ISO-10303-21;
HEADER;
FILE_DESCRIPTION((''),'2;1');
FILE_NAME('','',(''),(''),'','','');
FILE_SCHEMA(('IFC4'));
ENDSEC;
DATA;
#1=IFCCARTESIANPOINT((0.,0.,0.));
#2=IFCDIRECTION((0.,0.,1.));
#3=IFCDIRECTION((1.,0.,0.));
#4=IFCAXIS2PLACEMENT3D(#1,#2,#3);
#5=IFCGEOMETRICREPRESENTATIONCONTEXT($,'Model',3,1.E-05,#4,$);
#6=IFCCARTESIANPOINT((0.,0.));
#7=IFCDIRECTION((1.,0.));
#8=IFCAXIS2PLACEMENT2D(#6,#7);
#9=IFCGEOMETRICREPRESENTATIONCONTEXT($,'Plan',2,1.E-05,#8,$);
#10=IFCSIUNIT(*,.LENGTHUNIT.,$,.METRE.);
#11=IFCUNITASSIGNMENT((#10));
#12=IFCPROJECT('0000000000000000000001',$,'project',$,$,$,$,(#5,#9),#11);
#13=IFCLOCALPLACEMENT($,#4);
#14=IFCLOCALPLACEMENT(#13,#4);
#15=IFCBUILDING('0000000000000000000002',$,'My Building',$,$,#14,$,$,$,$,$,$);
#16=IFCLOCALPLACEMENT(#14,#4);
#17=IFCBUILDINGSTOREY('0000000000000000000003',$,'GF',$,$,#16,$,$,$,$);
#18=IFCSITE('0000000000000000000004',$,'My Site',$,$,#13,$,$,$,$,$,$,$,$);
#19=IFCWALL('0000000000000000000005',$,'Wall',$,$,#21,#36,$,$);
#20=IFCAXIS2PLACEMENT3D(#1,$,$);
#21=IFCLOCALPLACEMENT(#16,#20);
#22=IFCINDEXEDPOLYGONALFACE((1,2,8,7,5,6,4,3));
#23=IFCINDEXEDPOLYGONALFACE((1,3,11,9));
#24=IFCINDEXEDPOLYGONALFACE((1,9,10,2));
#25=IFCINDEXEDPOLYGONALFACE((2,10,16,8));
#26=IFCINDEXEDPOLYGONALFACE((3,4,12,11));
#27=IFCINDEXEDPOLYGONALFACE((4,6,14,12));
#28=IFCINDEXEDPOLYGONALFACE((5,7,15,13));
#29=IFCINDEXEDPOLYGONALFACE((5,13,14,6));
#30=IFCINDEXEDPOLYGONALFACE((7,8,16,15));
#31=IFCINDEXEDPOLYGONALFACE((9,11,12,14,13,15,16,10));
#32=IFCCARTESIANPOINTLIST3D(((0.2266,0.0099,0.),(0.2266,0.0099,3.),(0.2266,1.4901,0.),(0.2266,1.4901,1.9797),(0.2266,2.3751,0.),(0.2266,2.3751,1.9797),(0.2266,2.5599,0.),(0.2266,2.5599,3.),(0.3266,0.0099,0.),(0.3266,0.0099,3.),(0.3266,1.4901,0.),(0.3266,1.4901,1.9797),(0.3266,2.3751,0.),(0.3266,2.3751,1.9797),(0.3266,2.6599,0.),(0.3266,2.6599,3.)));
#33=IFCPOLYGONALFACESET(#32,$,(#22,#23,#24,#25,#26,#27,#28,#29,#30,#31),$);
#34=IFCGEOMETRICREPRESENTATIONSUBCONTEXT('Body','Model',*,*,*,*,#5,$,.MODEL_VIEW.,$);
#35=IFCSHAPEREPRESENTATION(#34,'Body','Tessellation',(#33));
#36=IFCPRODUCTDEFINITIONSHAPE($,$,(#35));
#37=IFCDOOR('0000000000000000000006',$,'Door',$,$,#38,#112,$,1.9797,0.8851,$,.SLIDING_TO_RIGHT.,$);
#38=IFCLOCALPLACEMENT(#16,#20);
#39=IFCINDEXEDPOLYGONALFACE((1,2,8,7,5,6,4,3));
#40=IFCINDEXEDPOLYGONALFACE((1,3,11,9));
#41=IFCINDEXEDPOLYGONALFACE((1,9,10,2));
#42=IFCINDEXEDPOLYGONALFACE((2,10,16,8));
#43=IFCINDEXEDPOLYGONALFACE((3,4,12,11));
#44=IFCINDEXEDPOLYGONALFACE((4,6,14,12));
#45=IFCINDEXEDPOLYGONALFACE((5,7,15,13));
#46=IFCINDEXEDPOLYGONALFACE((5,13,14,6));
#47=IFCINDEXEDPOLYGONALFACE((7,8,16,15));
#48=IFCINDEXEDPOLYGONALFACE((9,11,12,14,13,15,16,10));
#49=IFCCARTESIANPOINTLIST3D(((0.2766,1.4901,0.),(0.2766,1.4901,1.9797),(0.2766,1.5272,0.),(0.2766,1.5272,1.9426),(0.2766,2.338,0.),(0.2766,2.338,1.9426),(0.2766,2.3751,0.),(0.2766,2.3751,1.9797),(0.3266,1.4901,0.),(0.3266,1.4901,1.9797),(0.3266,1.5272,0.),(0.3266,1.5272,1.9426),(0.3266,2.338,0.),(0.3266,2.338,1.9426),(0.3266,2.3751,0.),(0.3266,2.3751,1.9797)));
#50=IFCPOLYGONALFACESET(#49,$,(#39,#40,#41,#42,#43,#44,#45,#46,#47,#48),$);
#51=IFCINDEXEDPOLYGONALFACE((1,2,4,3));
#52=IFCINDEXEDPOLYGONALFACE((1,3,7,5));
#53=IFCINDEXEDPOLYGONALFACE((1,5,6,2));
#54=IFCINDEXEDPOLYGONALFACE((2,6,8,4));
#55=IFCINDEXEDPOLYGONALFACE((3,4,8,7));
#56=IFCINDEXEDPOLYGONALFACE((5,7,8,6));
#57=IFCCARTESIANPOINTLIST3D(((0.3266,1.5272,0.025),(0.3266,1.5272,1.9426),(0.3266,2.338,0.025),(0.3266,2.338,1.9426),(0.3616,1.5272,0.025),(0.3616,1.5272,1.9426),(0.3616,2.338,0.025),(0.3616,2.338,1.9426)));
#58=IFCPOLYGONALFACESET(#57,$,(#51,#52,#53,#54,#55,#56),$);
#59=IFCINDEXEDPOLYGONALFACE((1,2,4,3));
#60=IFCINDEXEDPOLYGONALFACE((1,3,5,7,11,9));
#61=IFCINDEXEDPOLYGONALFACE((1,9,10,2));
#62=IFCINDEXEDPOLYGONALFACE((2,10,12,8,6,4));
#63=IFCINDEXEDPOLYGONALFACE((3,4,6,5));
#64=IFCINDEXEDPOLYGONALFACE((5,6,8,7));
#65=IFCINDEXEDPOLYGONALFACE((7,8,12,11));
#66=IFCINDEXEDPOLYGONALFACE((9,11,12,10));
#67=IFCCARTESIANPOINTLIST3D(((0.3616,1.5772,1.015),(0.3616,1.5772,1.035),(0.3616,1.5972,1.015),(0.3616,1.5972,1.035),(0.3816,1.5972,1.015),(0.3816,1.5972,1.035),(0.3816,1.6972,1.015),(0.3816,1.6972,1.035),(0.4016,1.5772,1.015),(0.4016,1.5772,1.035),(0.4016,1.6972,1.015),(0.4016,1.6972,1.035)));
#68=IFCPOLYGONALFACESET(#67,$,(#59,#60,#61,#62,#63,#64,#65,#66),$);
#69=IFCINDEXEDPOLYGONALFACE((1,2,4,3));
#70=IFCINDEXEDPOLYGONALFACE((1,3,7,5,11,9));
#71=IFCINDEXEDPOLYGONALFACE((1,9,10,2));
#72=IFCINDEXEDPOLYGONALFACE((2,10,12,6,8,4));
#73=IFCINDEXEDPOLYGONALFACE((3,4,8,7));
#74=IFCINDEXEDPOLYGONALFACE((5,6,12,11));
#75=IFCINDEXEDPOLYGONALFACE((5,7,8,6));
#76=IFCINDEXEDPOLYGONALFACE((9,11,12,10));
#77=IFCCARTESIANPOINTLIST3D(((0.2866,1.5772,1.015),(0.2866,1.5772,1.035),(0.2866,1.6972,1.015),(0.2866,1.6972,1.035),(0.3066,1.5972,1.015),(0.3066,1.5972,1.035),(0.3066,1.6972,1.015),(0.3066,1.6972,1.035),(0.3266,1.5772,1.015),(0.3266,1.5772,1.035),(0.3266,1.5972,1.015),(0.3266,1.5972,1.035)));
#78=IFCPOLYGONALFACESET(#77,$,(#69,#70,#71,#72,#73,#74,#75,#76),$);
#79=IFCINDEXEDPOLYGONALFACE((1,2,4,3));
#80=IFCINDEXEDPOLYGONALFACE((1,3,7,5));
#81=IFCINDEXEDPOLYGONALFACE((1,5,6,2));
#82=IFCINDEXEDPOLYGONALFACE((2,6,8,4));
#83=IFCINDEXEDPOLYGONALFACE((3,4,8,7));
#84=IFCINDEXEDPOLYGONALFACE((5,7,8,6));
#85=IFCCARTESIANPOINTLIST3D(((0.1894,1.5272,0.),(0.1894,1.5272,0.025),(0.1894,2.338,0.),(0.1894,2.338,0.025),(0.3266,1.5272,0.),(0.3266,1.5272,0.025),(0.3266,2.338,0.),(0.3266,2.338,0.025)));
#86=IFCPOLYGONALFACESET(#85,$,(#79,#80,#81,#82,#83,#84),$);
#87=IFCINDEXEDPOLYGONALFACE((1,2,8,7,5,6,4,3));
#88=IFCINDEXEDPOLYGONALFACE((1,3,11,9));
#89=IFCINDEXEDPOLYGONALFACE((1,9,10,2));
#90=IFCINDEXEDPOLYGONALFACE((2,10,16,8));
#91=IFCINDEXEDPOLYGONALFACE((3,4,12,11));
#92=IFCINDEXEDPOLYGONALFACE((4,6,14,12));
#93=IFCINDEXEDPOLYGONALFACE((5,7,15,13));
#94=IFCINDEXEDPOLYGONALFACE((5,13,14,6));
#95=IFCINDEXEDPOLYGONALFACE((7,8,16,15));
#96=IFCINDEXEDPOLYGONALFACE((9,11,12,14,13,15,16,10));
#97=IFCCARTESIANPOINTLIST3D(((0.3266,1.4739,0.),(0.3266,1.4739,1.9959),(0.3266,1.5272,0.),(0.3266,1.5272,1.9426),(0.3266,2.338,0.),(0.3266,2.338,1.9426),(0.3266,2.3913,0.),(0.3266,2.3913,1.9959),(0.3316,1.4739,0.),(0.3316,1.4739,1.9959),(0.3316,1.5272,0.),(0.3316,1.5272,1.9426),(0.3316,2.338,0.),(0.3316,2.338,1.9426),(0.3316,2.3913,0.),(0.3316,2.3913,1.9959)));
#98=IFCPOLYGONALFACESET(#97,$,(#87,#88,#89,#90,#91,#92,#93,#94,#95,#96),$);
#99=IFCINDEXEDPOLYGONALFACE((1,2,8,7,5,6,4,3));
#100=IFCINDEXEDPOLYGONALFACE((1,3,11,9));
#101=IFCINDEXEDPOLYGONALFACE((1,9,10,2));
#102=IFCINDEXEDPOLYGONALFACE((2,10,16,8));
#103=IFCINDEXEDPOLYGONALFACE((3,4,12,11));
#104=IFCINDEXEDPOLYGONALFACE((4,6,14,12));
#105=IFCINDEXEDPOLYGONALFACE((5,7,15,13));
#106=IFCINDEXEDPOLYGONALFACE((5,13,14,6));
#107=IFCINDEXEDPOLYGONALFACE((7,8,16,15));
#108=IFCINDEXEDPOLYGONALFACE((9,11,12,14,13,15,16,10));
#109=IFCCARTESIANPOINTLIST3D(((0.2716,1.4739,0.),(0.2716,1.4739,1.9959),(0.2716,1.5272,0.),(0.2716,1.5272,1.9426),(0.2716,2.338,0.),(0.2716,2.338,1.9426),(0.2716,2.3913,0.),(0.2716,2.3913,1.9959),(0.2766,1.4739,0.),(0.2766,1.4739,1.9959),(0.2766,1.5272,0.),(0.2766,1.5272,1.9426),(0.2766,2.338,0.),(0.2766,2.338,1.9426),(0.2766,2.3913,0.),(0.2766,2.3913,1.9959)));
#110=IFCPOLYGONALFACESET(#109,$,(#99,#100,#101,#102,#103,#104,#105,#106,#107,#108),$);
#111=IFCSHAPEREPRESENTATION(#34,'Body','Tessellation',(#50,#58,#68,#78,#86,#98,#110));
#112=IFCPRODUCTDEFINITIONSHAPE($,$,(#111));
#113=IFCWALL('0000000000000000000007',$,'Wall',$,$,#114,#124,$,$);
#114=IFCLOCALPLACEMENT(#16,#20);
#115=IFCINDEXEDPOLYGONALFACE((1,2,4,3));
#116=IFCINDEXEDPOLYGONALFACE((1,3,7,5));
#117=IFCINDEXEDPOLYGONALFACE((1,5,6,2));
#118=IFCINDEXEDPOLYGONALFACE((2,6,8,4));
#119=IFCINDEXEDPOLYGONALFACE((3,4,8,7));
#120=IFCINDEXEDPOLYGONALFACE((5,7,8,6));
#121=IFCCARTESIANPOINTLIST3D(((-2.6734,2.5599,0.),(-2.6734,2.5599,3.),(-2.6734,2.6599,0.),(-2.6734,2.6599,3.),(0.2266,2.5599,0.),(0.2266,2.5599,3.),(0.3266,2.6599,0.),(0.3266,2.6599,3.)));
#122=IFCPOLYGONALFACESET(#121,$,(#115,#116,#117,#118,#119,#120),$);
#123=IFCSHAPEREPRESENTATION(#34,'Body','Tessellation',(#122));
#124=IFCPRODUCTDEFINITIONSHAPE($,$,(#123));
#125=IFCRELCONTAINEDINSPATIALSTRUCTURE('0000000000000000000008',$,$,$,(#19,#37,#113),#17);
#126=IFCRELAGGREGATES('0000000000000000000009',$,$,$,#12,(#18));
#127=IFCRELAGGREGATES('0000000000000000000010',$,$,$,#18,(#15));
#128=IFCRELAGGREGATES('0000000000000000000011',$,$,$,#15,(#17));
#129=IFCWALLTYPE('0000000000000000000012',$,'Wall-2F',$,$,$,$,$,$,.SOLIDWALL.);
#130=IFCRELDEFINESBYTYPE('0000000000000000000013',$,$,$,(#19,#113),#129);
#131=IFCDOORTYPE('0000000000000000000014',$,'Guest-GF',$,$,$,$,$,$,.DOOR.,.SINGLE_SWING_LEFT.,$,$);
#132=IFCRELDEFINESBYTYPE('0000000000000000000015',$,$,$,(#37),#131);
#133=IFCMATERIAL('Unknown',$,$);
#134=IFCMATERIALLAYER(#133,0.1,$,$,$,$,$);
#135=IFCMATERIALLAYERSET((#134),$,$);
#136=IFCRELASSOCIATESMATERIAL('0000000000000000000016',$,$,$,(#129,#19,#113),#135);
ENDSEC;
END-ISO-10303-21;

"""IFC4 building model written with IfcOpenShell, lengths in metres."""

from ifc_helpers import new_model, entity, si_unit, frame, origin_with_axes, origin_2d_with_axis, place, context, subcontext, project, spatial, line, indexed_curve, outline, extrude, shape, source, transform, mapped, material, layer, layer_set, layer_usage, type_object, type_shapes, element, fill, save


model = new_model("IFC4")

# Units and contexts
model_context = context("Model", 3, precision=1e-05, world=origin_with_axes())
plan_context = context("Plan", 2, precision=1e-05, world=origin_2d_with_axis())
body_context_1 = subcontext(model_context, "Body", "Model", "MODEL_VIEW")
body_context_2 = subcontext(plan_context, "Body", "Plan", "PLAN_VIEW")
ifc_project = project(units=[si_unit("LENGTHUNIT", "METRE")], contexts=[model_context, plan_context])

# Site, building, storey
site_placement = place(None, origin_with_axes())
site = spatial("IfcSite", under=ifc_project, at=site_placement, Name="My Site")
building_placement = place(site_placement, origin_with_axes())
building = spatial("IfcBuilding", under=site, at=building_placement, Name="My Building")
storey_placement = place(building_placement, origin_with_axes())
storey = spatial("IfcBuildingStorey", under=building, at=storey_placement, Name="GF")

# Shared definitions
ifc_material = material(Name="Unknown")

# Shared definitions
ifc_layer_1 = layer(ifc_material, 0.1)
ifc_layer_set_1 = layer_set([ifc_layer_1])
wall_type = type_object("IfcWallType", Name="Wall-2F", PredefinedType="SOLIDWALL", material=ifc_layer_set_1)

# Wall, opening, door
ifc_layer_usage_1 = layer_usage(ifc_layer_set_1, "AXIS2", "POSITIVE", 0.0)
wall_1_placement = place(storey_placement, frame((0.3266, 0.0099, 0.0), z_axis=(0.0, 0.0, 1.0), x_axis=(0.0, 1.0, 0.0)))
wall_1 = element("IfcWall", 1, at=wall_1_placement, inside=storey, type_object=wall_type, material=ifc_layer_usage_1, Name="Wall", context=body_context_1, shape_type="SweptSolid", body=[
    extrude(outline(indexed_curve([(0.0, 0.0), (0.0, 0.1), (2.55, 0.1), (2.65, 0.0)], segments=[line(1, 2, 3, 4, 1)])), origin_with_axes(), (0.0, 0.0, 1.0), 3.0),
])
shared_shape_1 = source(origin_with_axes(), body_context_1, "Body", "SweptSolid", [
    extrude(outline(indexed_curve([(0.0, 0.0), (0.8851, 0.0), (0.8851, 1.9797), (0.0, 1.9797)], segments=[line(1, 2, 3, 4, 1)])), frame((0.0, -0.6, 0.0), z_axis=(0.0, -1.0, 0.0), x_axis=(1.0, 0.0, 0.0)), (0.0, 0.0, -1.0), 1.2),
])
opening_1_placement = place(wall_1_placement, frame((1.4802, 0.0, 0.0), z_axis=(0.0, 0.0, 1.0), x_axis=(1.0, 0.0, 0.0)))
opening_1 = element("IfcOpeningElement", 2, at=opening_1_placement, cuts=wall_1, PredefinedType="OPENING", context=body_context_1, shape_type="MappedRepresentation", body=[
    mapped(shared_shape_1, transform((0.0, 0.0, 0.0), x_axis=(1.0, 0.0, 0.0), y_axis=(0.0, 1.0, 0.0), z_axis=(0.0, 0.0, 1.0), scale=1.0)),
])
door_type_1 = type_object("IfcDoorType", Name="Guest-GF", OperationType="SINGLE_SWING_LEFT", PredefinedType="DOOR")
shared_shape_2 = source(origin_with_axes(), body_context_1, "Body", "SweptSolid", [
    extrude(outline(indexed_curve([(0.0, 0.0), (0.0, 1.9797), (0.8851, 1.9797), (0.8851, 0.0), (0.848, 0.0), (0.848, 1.9426), (0.0371, 1.9426), (0.0371, 0.0)], segments=[line(1, 2, 3, 4, 5, 6, 7, 8, 1)])), frame((0.0, 0.0, 0.0), z_axis=(0.0, -1.0, 0.0), x_axis=(1.0, 0.0, 0.0)), (0.0, 0.0, -1.0), 0.05),
    extrude(outline(indexed_curve([(0.0, 0.0), (0.8109, 0.0), (0.8109, 0.035), (0.0, 0.035)], segments=[line(1, 2, 3, 4, 1)])), frame((0.0371, -0.035, 0.025), z_axis=(0.0, 0.0, 1.0), x_axis=(1.0, 0.0, 0.0)), (0.0, 0.0, 1.0), 1.9176),
    extrude(outline(indexed_curve([(0.0, 0.0), (0.0, -0.04), (0.12, -0.04), (0.12, -0.02), (0.02, -0.02), (0.02, 0.0)], segments=[line(1, 2, 3, 4, 5, 6, 1)])), frame((0.0871, -0.035, 1.015), z_axis=(0.0, 0.0, 1.0), x_axis=(1.0, 0.0, 0.0)), (0.0, 0.0, 1.0), 0.02),
    extrude(outline(indexed_curve([(0.0, 0.0), (0.0, 0.04), (0.12, 0.04), (0.12, 0.02), (0.02, 0.02), (0.02, 0.0)], segments=[line(1, 2, 3, 4, 5, 6, 1)])), frame((0.0871, 0.0, 1.015), z_axis=(0.0, 0.0, 1.0), x_axis=(1.0, 0.0, 0.0)), (0.0, 0.0, 1.0), 0.02),
    extrude(outline(indexed_curve([(0.0, 0.0), (0.8109, 0.0), (0.8109, 0.1372), (0.0, 0.1372)], segments=[line(1, 2, 3, 4, 1)])), frame((0.0371, 0.0, 0.0), z_axis=(0.0, 0.0, 1.0), x_axis=(1.0, 0.0, 0.0)), (0.0, 0.0, 1.0), 0.025),
    extrude(outline(indexed_curve([(0.0, 0.0), (0.0, 1.9959), (0.9174, 1.9959), (0.9174, 0.0), (0.8641, 0.0), (0.8641, 1.9426), (0.0532, 1.9426), (0.0532, 0.0)], segments=[line(1, 2, 3, 4, 5, 6, 7, 8, 1)])), frame((-0.0162, -0.005, 0.0), z_axis=(0.0, -1.0, 0.0), x_axis=(1.0, 0.0, 0.0)), (0.0, 0.0, -1.0), 0.005),
    extrude(outline(indexed_curve([(0.0, 0.0), (0.0, 1.9959), (0.9174, 1.9959), (0.9174, 0.0), (0.8641, 0.0), (0.8641, 1.9426), (0.0532, 1.9426), (0.0532, 0.0)], segments=[line(1, 2, 3, 4, 5, 6, 7, 8, 1)])), frame((-0.0162, 0.05, 0.0), z_axis=(0.0, -1.0, 0.0), x_axis=(1.0, 0.0, 0.0)), (0.0, 0.0, -1.0), 0.005),
])
shared_shape_3 = source(origin_with_axes(), body_context_2, "Body", "Curve2D", [
    entity("IfcIndexedPolyCurve", entity("IfcCartesianPointList2D", [[0.0, 0.0], [0.0371, 0.0], [0.0371, 0.05], [0.0, 0.05]]), [entity("IfcLineIndex", [1, 2, 3, 4, 1])]),
    entity("IfcIndexedPolyCurve", entity("IfcCartesianPointList2D", [[0.8851, 0.0], [0.848, 0.0], [0.848, 0.05], [0.8851, 0.05]]), [entity("IfcLineIndex", [1, 2, 3, 4, 1])]),
    entity("IfcIndexedPolyCurve", entity("IfcCartesianPointList2D", [[1.2534, -0.035], [0.4425, -0.035], [0.4425, 0.0], [1.2534, 0.0]]), [entity("IfcLineIndex", [1, 2, 3, 4, 1])]),
])
type_shapes(door_type_1, [shared_shape_2, shared_shape_3])
door_1_placement = place(opening_1_placement, frame((0.0, 0.0, 0.0), z_axis=(0.0, 0.0, 1.0), x_axis=(1.0, 0.0, 0.0)))
door_1 = element("IfcDoor", 3, at=door_1_placement, inside=storey, type_object=door_type_1, Name="Door", OperationType="SLIDING_TO_RIGHT", OverallHeight=1.9797, OverallWidth=0.8851, shapes=[
    shape(body_context_1, "Body", "MappedRepresentation", [mapped(shared_shape_2, transform((0.0, 0.0, 0.0), x_axis=(1.0, 0.0, 0.0), y_axis=(0.0, 1.0, 0.0), z_axis=(0.0, 0.0, 1.0), scale=1.0))]),
    shape(body_context_2, "Body", "MappedRepresentation", [mapped(shared_shape_3, transform((0.0, 0.0, 0.0), x_axis=(1.0, 0.0, 0.0), y_axis=(0.0, 1.0, 0.0), z_axis=(0.0, 0.0, 1.0), scale=1.0))]),
])
fill(opening_1, door_1)

# Wall
ifc_layer_usage_2 = layer_usage(ifc_layer_set_1, "AXIS2", "POSITIVE", 0.0)
wall_2_placement = place(storey_placement, frame((0.3266, 2.6599, 0.0), z_axis=(0.0, 0.0, 1.0), x_axis=(-1.0, 0.0, 0.0)))
element("IfcWall", 4, at=wall_2_placement, inside=storey, type_object=wall_type, material=ifc_layer_usage_2, Name="Wall", context=body_context_1, shape_type="SweptSolid", body=[
    extrude(outline(indexed_curve([(0.0, 0.0), (0.1, 0.1), (3.0, 0.1), (3.0, 0.0)], segments=[line(1, 2, 3, 4, 1)])), origin_with_axes(), (0.0, 0.0, 1.0), 3.0),
])

save(model, "model.ifc")
